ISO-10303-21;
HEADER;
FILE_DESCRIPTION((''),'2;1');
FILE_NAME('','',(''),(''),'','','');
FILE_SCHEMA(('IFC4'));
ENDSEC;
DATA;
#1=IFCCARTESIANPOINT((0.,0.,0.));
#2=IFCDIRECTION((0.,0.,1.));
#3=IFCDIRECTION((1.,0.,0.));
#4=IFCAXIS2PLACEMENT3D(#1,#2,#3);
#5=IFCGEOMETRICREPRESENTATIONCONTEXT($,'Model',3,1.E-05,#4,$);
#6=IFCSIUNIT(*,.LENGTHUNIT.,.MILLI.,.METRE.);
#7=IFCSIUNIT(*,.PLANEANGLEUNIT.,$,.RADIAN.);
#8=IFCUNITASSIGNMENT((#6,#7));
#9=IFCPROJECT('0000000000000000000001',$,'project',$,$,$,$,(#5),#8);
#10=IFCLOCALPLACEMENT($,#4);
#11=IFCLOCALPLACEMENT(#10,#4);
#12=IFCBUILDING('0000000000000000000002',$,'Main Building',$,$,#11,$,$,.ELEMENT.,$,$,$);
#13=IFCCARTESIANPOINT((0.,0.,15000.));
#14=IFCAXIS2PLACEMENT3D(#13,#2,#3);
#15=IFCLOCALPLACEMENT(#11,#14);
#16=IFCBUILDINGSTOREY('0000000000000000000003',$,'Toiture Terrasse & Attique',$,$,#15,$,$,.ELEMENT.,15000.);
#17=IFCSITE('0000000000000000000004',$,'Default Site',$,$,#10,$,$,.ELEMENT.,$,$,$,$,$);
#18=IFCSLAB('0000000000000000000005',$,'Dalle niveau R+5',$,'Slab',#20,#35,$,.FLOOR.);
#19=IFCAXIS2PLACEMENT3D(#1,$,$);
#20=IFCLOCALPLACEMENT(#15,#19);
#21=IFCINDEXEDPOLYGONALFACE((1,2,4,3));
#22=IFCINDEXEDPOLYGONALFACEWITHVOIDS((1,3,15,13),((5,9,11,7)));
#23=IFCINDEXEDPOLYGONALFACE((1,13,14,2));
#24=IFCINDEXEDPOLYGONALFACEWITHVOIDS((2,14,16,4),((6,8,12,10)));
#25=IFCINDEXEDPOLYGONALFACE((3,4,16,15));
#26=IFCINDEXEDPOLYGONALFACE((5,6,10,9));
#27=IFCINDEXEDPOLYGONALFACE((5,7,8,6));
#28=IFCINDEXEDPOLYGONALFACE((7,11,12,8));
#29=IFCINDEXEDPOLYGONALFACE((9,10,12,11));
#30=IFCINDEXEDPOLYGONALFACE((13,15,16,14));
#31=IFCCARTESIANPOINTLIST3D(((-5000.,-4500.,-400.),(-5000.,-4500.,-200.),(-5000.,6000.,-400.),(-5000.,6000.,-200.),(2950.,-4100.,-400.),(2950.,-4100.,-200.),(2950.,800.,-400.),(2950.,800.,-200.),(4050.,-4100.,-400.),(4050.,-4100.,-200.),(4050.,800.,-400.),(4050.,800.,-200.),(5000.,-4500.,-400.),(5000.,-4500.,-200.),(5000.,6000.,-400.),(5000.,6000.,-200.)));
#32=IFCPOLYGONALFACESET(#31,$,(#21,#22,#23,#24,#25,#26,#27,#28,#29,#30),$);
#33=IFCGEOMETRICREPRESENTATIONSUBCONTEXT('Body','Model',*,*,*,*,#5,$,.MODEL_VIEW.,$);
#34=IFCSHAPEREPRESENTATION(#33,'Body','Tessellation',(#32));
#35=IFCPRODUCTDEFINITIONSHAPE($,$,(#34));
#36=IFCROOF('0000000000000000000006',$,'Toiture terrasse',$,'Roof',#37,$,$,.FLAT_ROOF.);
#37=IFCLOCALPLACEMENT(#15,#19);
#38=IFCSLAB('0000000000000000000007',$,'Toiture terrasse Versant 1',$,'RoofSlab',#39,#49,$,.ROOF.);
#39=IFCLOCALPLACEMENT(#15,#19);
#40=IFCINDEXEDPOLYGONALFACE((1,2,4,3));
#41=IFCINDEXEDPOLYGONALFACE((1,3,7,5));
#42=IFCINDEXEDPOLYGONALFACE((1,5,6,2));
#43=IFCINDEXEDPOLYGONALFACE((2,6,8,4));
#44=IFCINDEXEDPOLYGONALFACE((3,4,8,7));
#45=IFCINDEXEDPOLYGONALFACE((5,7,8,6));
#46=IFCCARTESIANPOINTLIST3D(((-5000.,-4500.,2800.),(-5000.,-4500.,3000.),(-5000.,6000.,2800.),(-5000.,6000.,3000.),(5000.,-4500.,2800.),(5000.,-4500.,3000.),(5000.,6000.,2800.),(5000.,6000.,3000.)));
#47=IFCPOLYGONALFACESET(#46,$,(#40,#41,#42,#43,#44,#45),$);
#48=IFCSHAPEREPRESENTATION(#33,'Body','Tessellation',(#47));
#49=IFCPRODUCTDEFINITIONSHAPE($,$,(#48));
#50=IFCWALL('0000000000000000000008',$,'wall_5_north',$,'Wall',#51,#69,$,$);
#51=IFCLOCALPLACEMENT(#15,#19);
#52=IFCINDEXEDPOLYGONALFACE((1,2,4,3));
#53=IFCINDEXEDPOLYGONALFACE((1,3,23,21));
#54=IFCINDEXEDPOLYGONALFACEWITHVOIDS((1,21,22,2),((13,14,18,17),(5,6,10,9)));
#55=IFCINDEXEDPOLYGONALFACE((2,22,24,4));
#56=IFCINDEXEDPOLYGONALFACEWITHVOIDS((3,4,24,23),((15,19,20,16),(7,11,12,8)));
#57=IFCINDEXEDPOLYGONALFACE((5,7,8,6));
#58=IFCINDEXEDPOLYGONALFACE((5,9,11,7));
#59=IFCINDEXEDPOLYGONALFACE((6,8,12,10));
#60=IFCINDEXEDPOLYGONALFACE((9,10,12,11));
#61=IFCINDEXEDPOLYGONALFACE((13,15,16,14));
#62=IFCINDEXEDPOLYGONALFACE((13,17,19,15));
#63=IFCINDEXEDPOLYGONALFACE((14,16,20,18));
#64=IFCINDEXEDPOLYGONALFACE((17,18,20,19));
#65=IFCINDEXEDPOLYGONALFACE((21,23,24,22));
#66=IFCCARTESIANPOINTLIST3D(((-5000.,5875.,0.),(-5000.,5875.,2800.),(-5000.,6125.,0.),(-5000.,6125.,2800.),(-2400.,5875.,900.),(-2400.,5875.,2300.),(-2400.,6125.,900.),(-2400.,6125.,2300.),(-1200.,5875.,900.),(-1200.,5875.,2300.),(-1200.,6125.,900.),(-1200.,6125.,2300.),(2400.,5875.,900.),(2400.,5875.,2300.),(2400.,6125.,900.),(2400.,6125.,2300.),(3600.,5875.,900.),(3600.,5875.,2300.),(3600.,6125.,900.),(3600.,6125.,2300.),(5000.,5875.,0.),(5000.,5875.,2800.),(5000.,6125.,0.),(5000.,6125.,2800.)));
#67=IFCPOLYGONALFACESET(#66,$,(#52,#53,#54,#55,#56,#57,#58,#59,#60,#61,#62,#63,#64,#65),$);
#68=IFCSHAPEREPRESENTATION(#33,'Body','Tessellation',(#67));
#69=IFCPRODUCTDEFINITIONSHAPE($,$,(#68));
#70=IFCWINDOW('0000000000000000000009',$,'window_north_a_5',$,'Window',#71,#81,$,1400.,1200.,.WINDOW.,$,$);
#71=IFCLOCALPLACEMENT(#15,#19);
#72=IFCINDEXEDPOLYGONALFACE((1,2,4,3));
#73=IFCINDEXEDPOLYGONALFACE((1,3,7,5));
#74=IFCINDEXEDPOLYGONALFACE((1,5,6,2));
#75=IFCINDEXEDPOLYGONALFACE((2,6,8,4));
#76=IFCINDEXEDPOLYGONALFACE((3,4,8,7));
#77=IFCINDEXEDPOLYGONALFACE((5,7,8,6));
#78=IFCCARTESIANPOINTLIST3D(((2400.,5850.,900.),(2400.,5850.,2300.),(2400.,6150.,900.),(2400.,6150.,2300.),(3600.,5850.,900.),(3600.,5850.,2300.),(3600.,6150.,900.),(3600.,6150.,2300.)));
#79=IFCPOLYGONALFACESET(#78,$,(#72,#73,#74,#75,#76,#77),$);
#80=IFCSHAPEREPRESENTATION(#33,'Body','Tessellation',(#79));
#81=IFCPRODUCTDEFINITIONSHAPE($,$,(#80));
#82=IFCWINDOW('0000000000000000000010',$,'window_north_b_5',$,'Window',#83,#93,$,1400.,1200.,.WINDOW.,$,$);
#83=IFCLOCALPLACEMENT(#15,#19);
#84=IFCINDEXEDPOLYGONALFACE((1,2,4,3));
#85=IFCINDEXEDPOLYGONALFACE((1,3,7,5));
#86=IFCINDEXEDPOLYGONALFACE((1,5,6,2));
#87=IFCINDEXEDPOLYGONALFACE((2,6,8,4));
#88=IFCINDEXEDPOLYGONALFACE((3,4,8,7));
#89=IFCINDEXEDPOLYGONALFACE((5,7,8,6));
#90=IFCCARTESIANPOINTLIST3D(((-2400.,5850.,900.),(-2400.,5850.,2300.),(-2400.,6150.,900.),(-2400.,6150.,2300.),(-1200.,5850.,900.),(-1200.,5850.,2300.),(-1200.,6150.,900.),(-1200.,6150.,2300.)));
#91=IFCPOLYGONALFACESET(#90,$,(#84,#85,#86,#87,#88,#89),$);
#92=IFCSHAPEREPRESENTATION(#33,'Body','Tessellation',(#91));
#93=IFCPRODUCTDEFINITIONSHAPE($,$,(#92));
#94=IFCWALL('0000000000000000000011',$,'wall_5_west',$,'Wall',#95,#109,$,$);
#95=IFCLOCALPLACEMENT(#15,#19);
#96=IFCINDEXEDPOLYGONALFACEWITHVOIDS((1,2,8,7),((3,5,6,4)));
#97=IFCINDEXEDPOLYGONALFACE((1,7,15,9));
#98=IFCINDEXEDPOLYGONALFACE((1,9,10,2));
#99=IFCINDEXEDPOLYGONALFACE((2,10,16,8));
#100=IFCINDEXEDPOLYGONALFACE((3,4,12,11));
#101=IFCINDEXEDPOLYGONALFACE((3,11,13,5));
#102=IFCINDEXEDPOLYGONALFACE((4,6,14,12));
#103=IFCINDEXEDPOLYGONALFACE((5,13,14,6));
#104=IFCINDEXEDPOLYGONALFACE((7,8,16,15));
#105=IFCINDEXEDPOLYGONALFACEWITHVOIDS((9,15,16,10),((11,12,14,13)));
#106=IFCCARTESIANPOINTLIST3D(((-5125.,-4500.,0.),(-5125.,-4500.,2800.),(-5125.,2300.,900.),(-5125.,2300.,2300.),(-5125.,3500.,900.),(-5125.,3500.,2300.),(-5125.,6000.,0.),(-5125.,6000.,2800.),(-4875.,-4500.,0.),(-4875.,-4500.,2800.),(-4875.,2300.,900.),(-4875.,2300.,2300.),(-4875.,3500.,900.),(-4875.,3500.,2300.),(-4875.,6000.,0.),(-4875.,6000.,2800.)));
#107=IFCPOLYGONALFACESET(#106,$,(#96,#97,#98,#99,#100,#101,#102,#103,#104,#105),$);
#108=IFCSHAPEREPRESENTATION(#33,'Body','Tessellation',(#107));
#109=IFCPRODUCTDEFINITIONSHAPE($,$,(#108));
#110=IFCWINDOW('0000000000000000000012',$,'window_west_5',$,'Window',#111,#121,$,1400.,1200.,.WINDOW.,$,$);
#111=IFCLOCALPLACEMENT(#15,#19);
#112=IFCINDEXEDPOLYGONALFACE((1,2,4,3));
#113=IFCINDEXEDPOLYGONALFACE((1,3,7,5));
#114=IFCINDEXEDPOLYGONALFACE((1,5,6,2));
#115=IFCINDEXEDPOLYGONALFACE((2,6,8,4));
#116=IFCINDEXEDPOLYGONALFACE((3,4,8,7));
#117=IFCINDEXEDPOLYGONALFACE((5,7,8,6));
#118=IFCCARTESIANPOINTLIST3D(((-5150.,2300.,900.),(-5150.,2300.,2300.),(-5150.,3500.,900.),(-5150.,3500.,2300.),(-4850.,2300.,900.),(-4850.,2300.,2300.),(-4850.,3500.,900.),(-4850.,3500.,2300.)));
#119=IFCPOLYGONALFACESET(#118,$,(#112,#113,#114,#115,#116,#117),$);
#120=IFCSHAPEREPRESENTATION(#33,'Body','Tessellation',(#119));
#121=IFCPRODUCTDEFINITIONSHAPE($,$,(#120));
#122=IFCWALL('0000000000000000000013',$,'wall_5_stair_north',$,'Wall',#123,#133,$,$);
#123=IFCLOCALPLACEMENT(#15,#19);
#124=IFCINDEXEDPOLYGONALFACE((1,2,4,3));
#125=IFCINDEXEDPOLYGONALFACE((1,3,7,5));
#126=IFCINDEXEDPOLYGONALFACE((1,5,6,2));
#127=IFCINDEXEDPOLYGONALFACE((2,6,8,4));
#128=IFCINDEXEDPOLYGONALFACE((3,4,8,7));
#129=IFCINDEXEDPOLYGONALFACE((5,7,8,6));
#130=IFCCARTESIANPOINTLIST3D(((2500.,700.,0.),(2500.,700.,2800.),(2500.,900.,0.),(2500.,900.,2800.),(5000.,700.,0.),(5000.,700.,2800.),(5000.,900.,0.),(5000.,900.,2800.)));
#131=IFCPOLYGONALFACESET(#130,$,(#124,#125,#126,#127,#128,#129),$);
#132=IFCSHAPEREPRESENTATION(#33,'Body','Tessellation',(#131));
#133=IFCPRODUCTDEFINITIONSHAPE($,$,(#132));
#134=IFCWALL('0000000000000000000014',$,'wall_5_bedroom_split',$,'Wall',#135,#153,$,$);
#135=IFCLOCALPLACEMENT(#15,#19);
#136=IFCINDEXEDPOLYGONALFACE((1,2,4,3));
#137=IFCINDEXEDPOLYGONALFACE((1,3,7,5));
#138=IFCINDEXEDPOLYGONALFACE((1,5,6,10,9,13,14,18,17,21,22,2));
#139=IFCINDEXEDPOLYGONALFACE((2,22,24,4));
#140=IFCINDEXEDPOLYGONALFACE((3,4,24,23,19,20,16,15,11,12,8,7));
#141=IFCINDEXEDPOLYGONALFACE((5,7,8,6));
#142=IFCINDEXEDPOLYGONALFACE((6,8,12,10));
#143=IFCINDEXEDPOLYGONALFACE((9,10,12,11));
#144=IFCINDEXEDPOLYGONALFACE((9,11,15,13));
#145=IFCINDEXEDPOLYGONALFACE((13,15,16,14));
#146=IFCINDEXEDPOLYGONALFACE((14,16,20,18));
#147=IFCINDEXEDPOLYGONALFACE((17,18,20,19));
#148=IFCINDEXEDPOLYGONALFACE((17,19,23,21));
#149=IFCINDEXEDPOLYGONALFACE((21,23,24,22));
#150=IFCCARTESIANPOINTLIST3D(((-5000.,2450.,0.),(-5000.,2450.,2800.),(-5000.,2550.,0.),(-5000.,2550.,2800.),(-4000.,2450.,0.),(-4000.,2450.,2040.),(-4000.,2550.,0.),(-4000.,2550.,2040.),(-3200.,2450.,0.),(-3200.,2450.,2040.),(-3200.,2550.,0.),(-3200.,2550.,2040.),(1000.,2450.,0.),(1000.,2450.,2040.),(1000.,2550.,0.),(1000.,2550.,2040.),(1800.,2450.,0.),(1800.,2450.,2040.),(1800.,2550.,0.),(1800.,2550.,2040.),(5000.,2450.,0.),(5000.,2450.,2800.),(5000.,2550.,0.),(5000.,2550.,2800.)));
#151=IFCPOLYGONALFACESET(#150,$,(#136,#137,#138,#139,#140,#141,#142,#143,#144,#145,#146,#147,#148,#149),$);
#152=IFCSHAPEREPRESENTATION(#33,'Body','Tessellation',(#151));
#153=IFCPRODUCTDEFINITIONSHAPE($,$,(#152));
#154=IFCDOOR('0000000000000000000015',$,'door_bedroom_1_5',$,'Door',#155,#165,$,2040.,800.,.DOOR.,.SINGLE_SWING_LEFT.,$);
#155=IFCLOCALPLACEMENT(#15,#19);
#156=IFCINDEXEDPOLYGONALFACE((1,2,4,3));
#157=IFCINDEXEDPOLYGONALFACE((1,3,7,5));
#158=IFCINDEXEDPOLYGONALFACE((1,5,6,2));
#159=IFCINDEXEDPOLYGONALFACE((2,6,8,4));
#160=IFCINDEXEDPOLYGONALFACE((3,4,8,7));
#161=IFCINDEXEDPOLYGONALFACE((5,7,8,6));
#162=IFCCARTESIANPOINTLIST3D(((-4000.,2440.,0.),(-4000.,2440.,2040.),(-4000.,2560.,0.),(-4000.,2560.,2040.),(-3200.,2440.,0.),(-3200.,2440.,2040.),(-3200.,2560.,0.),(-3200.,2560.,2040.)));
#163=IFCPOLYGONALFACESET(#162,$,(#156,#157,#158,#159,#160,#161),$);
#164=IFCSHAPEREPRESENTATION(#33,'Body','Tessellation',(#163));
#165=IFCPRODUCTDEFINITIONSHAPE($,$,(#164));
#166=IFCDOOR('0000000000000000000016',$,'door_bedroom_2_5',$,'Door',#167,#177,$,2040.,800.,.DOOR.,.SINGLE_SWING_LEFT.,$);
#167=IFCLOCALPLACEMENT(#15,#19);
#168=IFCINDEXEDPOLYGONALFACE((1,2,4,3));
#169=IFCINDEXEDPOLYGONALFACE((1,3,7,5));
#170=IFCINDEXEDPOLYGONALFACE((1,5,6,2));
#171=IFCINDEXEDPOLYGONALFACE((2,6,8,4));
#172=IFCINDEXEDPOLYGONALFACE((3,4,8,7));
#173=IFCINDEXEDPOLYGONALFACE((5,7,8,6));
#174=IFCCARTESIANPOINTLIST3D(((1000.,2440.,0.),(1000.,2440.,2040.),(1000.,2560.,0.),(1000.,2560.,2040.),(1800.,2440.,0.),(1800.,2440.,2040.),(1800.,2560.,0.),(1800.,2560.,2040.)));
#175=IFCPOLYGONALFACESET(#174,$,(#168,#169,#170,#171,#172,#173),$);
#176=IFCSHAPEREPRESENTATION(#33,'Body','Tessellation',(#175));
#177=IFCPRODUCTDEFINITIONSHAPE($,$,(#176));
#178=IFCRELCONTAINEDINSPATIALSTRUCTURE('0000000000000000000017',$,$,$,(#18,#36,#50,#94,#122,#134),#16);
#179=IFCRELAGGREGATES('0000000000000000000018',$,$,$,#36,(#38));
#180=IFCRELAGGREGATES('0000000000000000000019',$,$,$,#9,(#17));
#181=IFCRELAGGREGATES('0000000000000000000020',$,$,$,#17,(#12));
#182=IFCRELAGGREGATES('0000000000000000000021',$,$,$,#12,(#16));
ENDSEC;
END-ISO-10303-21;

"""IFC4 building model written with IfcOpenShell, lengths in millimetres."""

from ifc_helpers import new_model, si_unit, frame, origin_with_axes, place, context, subcontext, project, spatial, polyline, outline, extrude, element, fill, aggregate, save


model = new_model("IFC4")

# Units and contexts
model_context = context("Model", 3, precision=1e-05, world=origin_with_axes())
body_context = subcontext(model_context, "Body", "Model", "MODEL_VIEW")
ifc_project = project(units=[si_unit("LENGTHUNIT", "METRE", prefix="MILLI"), si_unit("PLANEANGLEUNIT", "RADIAN")], contexts=[model_context])

# Site, building, storey
site_placement = place(None, origin_with_axes())
site = spatial("IfcSite", under=ifc_project, at=site_placement, Name="Default Site", CompositionType="ELEMENT")
building_placement = place(site_placement, origin_with_axes())
building = spatial("IfcBuilding", under=site, at=building_placement, Name="Main Building", CompositionType="ELEMENT")
storey_placement = place(building_placement, frame((0.0, 0.0, 15000.0), z_axis=(0.0, 0.0, 1.0), x_axis=(1.0, 0.0, 0.0)))
storey = spatial("IfcBuildingStorey", under=building, at=storey_placement, Name="Toiture Terrasse & Attique", CompositionType="ELEMENT", Elevation=15000.0)

# Slab
slab_1_placement = place(storey_placement, frame((0.0, 0.0, -400.0), z_axis=(0.0, 0.0, 1.0), x_axis=(1.0, 0.0, 0.0)))
element("IfcSlab", 1, at=slab_1_placement, inside=storey, Name="Dalle niveau R+5", ObjectType="Slab", PredefinedType="FLOOR", context=body_context, shape_type="SweptSolid", body=[
    extrude(outline(polyline([(-5000.0, -4500.0), (5000.0, -4500.0), (5000.0, 6000.0), (-5000.0, 6000.0), (-5000.0, -4500.0)]), holes=[polyline([(2950.0, -4100.0), (2950.0, 800.0), (4050.0, 800.0), (4050.0, -4100.0), (2950.0, -4100.0)])]), origin_with_axes(), (0.0, 0.0, 1.0), 200.0),
])

# Roof, slab
roof_placement = place(storey_placement, frame((0.0, 0.0, 2800.0), z_axis=(0.0, 0.0, 1.0), x_axis=(1.0, 0.0, 0.0)))
roof = element("IfcRoof", 2, at=roof_placement, inside=storey, Name="Toiture terrasse", ObjectType="Roof", PredefinedType="FLAT_ROOF")
slab_2_placement = place(roof_placement, origin_with_axes())
slab_2 = element("IfcSlab", 3, at=slab_2_placement, Name="Toiture terrasse Versant 1", ObjectType="RoofSlab", PredefinedType="ROOF", context=body_context, shape_type="SweptSolid", body=[
    extrude(outline(polyline([(-5000.0, -4500.0), (5000.0, -4500.0), (5000.0, 6000.0), (-5000.0, 6000.0), (-5000.0, -4500.0)])), origin_with_axes(), (0.0, 0.0, 1.0), 200.0),
])
aggregate(roof, [slab_2])

# Wall, openings, windows
wall_1_placement = place(storey_placement, frame((5000.0, 6000.0, 0.0), z_axis=(0.0, 0.0, 1.0), x_axis=(-1.0, 0.0, 0.0)))
wall_1 = element("IfcWall", 4, at=wall_1_placement, inside=storey, Name="wall_5_north", ObjectType="Wall", context=body_context, shape_type="SweptSolid", body=[
    extrude(outline(polyline([(0.0, -125.0), (10000.0, -125.0), (10000.0, 125.0), (0.0, 125.0), (0.0, -125.0)])), origin_with_axes(), (0.0, 0.0, 1.0), 2800.0),
])
placement_1 = place(wall_1_placement, frame((1400.0, 0.0, 900.0), z_axis=(0.0, 0.0, 1.0), x_axis=(1.0, 0.0, 0.0)))
opening_1 = element("IfcOpeningElement", 5, at=placement_1, cuts=wall_1, PredefinedType="OPENING", context=body_context, shape_type="SweptSolid", body=[
    extrude(outline(polyline([(0.0, -150.0), (1200.0, -150.0), (1200.0, 150.0), (0.0, 150.0), (0.0, -150.0)])), origin_with_axes(), (0.0, 0.0, 1.0), 1400.0),
])
placement_2 = place(wall_1_placement, frame((6200.0, 0.0, 900.0), z_axis=(0.0, 0.0, 1.0), x_axis=(1.0, 0.0, 0.0)))
opening_2 = element("IfcOpeningElement", 6, at=placement_2, cuts=wall_1, PredefinedType="OPENING", context=body_context, shape_type="SweptSolid", body=[
    extrude(outline(polyline([(0.0, -150.0), (1200.0, -150.0), (1200.0, 150.0), (0.0, 150.0), (0.0, -150.0)])), origin_with_axes(), (0.0, 0.0, 1.0), 1400.0),
])
window_1 = element("IfcWindow", 7, at=placement_1, Name="window_north_a_5", ObjectType="Window", OverallHeight=1400.0, OverallWidth=1200.0, PredefinedType="WINDOW", context=body_context, shape_type="SweptSolid", body=[
    extrude(outline(polyline([(0.0, -150.0), (1200.0, -150.0), (1200.0, 150.0), (0.0, 150.0), (0.0, -150.0)])), origin_with_axes(), (0.0, 0.0, 1.0), 1400.0),
])
fill(opening_1, window_1)
window_2 = element("IfcWindow", 8, at=placement_2, Name="window_north_b_5", ObjectType="Window", OverallHeight=1400.0, OverallWidth=1200.0, PredefinedType="WINDOW", context=body_context, shape_type="SweptSolid", body=[
    extrude(outline(polyline([(0.0, -150.0), (1200.0, -150.0), (1200.0, 150.0), (0.0, 150.0), (0.0, -150.0)])), origin_with_axes(), (0.0, 0.0, 1.0), 1400.0),
])
fill(opening_2, window_2)

# Wall, opening, window
wall_2_placement = place(storey_placement, frame((-5000.0, 6000.0, 0.0), z_axis=(0.0, 0.0, 1.0), x_axis=(0.0, -1.0, 0.0)))
wall_2 = element("IfcWall", 9, at=wall_2_placement, inside=storey, Name="wall_5_west", ObjectType="Wall", context=body_context, shape_type="SweptSolid", body=[
    extrude(outline(polyline([(0.0, -125.0), (10500.0, -125.0), (10500.0, 125.0), (0.0, 125.0), (0.0, -125.0)])), origin_with_axes(), (0.0, 0.0, 1.0), 2800.0),
])
placement_3 = place(wall_2_placement, frame((2500.0, 0.0, 900.0), z_axis=(0.0, 0.0, 1.0), x_axis=(1.0, 0.0, 0.0)))
opening_3 = element("IfcOpeningElement", 10, at=placement_3, cuts=wall_2, PredefinedType="OPENING", context=body_context, shape_type="SweptSolid", body=[
    extrude(outline(polyline([(0.0, -150.0), (1200.0, -150.0), (1200.0, 150.0), (0.0, 150.0), (0.0, -150.0)])), origin_with_axes(), (0.0, 0.0, 1.0), 1400.0),
])
window_3 = element("IfcWindow", 11, at=placement_3, Name="window_west_5", ObjectType="Window", OverallHeight=1400.0, OverallWidth=1200.0, PredefinedType="WINDOW", context=body_context, shape_type="SweptSolid", body=[
    extrude(outline(polyline([(0.0, -150.0), (1200.0, -150.0), (1200.0, 150.0), (0.0, 150.0), (0.0, -150.0)])), origin_with_axes(), (0.0, 0.0, 1.0), 1400.0),
])
fill(opening_3, window_3)

# Wall
wall_3_placement = place(storey_placement, frame((2500.0, 800.0, 0.0), z_axis=(0.0, 0.0, 1.0), x_axis=(1.0, 0.0, 0.0)))
element("IfcWall", 12, at=wall_3_placement, inside=storey, Name="wall_5_stair_north", ObjectType="Wall", context=body_context, shape_type="SweptSolid", body=[
    extrude(outline(polyline([(0.0, -100.0), (2500.0, -100.0), (2500.0, 100.0), (0.0, 100.0), (0.0, -100.0)])), origin_with_axes(), (0.0, 0.0, 1.0), 2800.0),
])

# Wall, openings, doors
wall_4_placement = place(storey_placement, frame((-5000.0, 2500.0, 0.0), z_axis=(0.0, 0.0, 1.0), x_axis=(1.0, 0.0, 0.0)))
wall_4 = element("IfcWall", 13, at=wall_4_placement, inside=storey, Name="wall_5_bedroom_split", ObjectType="Wall", context=body_context, shape_type="SweptSolid", body=[
    extrude(outline(polyline([(0.0, -50.0), (10000.0, -50.0), (10000.0, 50.0), (0.0, 50.0), (0.0, -50.0)])), origin_with_axes(), (0.0, 0.0, 1.0), 2800.0),
])
placement_4 = place(wall_4_placement, frame((1000.0, 0.0, 0.0), z_axis=(0.0, 0.0, 1.0), x_axis=(1.0, 0.0, 0.0)))
opening_4 = element("IfcOpeningElement", 14, at=placement_4, cuts=wall_4, PredefinedType="OPENING", context=body_context, shape_type="SweptSolid", body=[
    extrude(outline(polyline([(0.0, -60.0), (800.0, -60.0), (800.0, 60.0), (0.0, 60.0), (0.0, -60.0)])), origin_with_axes(), (0.0, 0.0, 1.0), 2040.0),
])
placement_5 = place(wall_4_placement, frame((6000.0, 0.0, 0.0), z_axis=(0.0, 0.0, 1.0), x_axis=(1.0, 0.0, 0.0)))
opening_5 = element("IfcOpeningElement", 15, at=placement_5, cuts=wall_4, PredefinedType="OPENING", context=body_context, shape_type="SweptSolid", body=[
    extrude(outline(polyline([(0.0, -60.0), (800.0, -60.0), (800.0, 60.0), (0.0, 60.0), (0.0, -60.0)])), origin_with_axes(), (0.0, 0.0, 1.0), 2040.0),
])
door_1 = element("IfcDoor", 16, at=placement_4, Name="door_bedroom_1_5", ObjectType="Door", OperationType="SINGLE_SWING_LEFT", OverallHeight=2040.0, OverallWidth=800.0, PredefinedType="DOOR", context=body_context, shape_type="SweptSolid", body=[
    extrude(outline(polyline([(0.0, -60.0), (800.0, -60.0), (800.0, 60.0), (0.0, 60.0), (0.0, -60.0)])), origin_with_axes(), (0.0, 0.0, 1.0), 2040.0),
])
fill(opening_4, door_1)
door_2 = element("IfcDoor", 17, at=placement_5, Name="door_bedroom_2_5", ObjectType="Door", OperationType="SINGLE_SWING_LEFT", OverallHeight=2040.0, OverallWidth=800.0, PredefinedType="DOOR", context=body_context, shape_type="SweptSolid", body=[
    extrude(outline(polyline([(0.0, -60.0), (800.0, -60.0), (800.0, 60.0), (0.0, 60.0), (0.0, -60.0)])), origin_with_axes(), (0.0, 0.0, 1.0), 2040.0),
])
fill(opening_5, door_2)

save(model, "model.ifc")
